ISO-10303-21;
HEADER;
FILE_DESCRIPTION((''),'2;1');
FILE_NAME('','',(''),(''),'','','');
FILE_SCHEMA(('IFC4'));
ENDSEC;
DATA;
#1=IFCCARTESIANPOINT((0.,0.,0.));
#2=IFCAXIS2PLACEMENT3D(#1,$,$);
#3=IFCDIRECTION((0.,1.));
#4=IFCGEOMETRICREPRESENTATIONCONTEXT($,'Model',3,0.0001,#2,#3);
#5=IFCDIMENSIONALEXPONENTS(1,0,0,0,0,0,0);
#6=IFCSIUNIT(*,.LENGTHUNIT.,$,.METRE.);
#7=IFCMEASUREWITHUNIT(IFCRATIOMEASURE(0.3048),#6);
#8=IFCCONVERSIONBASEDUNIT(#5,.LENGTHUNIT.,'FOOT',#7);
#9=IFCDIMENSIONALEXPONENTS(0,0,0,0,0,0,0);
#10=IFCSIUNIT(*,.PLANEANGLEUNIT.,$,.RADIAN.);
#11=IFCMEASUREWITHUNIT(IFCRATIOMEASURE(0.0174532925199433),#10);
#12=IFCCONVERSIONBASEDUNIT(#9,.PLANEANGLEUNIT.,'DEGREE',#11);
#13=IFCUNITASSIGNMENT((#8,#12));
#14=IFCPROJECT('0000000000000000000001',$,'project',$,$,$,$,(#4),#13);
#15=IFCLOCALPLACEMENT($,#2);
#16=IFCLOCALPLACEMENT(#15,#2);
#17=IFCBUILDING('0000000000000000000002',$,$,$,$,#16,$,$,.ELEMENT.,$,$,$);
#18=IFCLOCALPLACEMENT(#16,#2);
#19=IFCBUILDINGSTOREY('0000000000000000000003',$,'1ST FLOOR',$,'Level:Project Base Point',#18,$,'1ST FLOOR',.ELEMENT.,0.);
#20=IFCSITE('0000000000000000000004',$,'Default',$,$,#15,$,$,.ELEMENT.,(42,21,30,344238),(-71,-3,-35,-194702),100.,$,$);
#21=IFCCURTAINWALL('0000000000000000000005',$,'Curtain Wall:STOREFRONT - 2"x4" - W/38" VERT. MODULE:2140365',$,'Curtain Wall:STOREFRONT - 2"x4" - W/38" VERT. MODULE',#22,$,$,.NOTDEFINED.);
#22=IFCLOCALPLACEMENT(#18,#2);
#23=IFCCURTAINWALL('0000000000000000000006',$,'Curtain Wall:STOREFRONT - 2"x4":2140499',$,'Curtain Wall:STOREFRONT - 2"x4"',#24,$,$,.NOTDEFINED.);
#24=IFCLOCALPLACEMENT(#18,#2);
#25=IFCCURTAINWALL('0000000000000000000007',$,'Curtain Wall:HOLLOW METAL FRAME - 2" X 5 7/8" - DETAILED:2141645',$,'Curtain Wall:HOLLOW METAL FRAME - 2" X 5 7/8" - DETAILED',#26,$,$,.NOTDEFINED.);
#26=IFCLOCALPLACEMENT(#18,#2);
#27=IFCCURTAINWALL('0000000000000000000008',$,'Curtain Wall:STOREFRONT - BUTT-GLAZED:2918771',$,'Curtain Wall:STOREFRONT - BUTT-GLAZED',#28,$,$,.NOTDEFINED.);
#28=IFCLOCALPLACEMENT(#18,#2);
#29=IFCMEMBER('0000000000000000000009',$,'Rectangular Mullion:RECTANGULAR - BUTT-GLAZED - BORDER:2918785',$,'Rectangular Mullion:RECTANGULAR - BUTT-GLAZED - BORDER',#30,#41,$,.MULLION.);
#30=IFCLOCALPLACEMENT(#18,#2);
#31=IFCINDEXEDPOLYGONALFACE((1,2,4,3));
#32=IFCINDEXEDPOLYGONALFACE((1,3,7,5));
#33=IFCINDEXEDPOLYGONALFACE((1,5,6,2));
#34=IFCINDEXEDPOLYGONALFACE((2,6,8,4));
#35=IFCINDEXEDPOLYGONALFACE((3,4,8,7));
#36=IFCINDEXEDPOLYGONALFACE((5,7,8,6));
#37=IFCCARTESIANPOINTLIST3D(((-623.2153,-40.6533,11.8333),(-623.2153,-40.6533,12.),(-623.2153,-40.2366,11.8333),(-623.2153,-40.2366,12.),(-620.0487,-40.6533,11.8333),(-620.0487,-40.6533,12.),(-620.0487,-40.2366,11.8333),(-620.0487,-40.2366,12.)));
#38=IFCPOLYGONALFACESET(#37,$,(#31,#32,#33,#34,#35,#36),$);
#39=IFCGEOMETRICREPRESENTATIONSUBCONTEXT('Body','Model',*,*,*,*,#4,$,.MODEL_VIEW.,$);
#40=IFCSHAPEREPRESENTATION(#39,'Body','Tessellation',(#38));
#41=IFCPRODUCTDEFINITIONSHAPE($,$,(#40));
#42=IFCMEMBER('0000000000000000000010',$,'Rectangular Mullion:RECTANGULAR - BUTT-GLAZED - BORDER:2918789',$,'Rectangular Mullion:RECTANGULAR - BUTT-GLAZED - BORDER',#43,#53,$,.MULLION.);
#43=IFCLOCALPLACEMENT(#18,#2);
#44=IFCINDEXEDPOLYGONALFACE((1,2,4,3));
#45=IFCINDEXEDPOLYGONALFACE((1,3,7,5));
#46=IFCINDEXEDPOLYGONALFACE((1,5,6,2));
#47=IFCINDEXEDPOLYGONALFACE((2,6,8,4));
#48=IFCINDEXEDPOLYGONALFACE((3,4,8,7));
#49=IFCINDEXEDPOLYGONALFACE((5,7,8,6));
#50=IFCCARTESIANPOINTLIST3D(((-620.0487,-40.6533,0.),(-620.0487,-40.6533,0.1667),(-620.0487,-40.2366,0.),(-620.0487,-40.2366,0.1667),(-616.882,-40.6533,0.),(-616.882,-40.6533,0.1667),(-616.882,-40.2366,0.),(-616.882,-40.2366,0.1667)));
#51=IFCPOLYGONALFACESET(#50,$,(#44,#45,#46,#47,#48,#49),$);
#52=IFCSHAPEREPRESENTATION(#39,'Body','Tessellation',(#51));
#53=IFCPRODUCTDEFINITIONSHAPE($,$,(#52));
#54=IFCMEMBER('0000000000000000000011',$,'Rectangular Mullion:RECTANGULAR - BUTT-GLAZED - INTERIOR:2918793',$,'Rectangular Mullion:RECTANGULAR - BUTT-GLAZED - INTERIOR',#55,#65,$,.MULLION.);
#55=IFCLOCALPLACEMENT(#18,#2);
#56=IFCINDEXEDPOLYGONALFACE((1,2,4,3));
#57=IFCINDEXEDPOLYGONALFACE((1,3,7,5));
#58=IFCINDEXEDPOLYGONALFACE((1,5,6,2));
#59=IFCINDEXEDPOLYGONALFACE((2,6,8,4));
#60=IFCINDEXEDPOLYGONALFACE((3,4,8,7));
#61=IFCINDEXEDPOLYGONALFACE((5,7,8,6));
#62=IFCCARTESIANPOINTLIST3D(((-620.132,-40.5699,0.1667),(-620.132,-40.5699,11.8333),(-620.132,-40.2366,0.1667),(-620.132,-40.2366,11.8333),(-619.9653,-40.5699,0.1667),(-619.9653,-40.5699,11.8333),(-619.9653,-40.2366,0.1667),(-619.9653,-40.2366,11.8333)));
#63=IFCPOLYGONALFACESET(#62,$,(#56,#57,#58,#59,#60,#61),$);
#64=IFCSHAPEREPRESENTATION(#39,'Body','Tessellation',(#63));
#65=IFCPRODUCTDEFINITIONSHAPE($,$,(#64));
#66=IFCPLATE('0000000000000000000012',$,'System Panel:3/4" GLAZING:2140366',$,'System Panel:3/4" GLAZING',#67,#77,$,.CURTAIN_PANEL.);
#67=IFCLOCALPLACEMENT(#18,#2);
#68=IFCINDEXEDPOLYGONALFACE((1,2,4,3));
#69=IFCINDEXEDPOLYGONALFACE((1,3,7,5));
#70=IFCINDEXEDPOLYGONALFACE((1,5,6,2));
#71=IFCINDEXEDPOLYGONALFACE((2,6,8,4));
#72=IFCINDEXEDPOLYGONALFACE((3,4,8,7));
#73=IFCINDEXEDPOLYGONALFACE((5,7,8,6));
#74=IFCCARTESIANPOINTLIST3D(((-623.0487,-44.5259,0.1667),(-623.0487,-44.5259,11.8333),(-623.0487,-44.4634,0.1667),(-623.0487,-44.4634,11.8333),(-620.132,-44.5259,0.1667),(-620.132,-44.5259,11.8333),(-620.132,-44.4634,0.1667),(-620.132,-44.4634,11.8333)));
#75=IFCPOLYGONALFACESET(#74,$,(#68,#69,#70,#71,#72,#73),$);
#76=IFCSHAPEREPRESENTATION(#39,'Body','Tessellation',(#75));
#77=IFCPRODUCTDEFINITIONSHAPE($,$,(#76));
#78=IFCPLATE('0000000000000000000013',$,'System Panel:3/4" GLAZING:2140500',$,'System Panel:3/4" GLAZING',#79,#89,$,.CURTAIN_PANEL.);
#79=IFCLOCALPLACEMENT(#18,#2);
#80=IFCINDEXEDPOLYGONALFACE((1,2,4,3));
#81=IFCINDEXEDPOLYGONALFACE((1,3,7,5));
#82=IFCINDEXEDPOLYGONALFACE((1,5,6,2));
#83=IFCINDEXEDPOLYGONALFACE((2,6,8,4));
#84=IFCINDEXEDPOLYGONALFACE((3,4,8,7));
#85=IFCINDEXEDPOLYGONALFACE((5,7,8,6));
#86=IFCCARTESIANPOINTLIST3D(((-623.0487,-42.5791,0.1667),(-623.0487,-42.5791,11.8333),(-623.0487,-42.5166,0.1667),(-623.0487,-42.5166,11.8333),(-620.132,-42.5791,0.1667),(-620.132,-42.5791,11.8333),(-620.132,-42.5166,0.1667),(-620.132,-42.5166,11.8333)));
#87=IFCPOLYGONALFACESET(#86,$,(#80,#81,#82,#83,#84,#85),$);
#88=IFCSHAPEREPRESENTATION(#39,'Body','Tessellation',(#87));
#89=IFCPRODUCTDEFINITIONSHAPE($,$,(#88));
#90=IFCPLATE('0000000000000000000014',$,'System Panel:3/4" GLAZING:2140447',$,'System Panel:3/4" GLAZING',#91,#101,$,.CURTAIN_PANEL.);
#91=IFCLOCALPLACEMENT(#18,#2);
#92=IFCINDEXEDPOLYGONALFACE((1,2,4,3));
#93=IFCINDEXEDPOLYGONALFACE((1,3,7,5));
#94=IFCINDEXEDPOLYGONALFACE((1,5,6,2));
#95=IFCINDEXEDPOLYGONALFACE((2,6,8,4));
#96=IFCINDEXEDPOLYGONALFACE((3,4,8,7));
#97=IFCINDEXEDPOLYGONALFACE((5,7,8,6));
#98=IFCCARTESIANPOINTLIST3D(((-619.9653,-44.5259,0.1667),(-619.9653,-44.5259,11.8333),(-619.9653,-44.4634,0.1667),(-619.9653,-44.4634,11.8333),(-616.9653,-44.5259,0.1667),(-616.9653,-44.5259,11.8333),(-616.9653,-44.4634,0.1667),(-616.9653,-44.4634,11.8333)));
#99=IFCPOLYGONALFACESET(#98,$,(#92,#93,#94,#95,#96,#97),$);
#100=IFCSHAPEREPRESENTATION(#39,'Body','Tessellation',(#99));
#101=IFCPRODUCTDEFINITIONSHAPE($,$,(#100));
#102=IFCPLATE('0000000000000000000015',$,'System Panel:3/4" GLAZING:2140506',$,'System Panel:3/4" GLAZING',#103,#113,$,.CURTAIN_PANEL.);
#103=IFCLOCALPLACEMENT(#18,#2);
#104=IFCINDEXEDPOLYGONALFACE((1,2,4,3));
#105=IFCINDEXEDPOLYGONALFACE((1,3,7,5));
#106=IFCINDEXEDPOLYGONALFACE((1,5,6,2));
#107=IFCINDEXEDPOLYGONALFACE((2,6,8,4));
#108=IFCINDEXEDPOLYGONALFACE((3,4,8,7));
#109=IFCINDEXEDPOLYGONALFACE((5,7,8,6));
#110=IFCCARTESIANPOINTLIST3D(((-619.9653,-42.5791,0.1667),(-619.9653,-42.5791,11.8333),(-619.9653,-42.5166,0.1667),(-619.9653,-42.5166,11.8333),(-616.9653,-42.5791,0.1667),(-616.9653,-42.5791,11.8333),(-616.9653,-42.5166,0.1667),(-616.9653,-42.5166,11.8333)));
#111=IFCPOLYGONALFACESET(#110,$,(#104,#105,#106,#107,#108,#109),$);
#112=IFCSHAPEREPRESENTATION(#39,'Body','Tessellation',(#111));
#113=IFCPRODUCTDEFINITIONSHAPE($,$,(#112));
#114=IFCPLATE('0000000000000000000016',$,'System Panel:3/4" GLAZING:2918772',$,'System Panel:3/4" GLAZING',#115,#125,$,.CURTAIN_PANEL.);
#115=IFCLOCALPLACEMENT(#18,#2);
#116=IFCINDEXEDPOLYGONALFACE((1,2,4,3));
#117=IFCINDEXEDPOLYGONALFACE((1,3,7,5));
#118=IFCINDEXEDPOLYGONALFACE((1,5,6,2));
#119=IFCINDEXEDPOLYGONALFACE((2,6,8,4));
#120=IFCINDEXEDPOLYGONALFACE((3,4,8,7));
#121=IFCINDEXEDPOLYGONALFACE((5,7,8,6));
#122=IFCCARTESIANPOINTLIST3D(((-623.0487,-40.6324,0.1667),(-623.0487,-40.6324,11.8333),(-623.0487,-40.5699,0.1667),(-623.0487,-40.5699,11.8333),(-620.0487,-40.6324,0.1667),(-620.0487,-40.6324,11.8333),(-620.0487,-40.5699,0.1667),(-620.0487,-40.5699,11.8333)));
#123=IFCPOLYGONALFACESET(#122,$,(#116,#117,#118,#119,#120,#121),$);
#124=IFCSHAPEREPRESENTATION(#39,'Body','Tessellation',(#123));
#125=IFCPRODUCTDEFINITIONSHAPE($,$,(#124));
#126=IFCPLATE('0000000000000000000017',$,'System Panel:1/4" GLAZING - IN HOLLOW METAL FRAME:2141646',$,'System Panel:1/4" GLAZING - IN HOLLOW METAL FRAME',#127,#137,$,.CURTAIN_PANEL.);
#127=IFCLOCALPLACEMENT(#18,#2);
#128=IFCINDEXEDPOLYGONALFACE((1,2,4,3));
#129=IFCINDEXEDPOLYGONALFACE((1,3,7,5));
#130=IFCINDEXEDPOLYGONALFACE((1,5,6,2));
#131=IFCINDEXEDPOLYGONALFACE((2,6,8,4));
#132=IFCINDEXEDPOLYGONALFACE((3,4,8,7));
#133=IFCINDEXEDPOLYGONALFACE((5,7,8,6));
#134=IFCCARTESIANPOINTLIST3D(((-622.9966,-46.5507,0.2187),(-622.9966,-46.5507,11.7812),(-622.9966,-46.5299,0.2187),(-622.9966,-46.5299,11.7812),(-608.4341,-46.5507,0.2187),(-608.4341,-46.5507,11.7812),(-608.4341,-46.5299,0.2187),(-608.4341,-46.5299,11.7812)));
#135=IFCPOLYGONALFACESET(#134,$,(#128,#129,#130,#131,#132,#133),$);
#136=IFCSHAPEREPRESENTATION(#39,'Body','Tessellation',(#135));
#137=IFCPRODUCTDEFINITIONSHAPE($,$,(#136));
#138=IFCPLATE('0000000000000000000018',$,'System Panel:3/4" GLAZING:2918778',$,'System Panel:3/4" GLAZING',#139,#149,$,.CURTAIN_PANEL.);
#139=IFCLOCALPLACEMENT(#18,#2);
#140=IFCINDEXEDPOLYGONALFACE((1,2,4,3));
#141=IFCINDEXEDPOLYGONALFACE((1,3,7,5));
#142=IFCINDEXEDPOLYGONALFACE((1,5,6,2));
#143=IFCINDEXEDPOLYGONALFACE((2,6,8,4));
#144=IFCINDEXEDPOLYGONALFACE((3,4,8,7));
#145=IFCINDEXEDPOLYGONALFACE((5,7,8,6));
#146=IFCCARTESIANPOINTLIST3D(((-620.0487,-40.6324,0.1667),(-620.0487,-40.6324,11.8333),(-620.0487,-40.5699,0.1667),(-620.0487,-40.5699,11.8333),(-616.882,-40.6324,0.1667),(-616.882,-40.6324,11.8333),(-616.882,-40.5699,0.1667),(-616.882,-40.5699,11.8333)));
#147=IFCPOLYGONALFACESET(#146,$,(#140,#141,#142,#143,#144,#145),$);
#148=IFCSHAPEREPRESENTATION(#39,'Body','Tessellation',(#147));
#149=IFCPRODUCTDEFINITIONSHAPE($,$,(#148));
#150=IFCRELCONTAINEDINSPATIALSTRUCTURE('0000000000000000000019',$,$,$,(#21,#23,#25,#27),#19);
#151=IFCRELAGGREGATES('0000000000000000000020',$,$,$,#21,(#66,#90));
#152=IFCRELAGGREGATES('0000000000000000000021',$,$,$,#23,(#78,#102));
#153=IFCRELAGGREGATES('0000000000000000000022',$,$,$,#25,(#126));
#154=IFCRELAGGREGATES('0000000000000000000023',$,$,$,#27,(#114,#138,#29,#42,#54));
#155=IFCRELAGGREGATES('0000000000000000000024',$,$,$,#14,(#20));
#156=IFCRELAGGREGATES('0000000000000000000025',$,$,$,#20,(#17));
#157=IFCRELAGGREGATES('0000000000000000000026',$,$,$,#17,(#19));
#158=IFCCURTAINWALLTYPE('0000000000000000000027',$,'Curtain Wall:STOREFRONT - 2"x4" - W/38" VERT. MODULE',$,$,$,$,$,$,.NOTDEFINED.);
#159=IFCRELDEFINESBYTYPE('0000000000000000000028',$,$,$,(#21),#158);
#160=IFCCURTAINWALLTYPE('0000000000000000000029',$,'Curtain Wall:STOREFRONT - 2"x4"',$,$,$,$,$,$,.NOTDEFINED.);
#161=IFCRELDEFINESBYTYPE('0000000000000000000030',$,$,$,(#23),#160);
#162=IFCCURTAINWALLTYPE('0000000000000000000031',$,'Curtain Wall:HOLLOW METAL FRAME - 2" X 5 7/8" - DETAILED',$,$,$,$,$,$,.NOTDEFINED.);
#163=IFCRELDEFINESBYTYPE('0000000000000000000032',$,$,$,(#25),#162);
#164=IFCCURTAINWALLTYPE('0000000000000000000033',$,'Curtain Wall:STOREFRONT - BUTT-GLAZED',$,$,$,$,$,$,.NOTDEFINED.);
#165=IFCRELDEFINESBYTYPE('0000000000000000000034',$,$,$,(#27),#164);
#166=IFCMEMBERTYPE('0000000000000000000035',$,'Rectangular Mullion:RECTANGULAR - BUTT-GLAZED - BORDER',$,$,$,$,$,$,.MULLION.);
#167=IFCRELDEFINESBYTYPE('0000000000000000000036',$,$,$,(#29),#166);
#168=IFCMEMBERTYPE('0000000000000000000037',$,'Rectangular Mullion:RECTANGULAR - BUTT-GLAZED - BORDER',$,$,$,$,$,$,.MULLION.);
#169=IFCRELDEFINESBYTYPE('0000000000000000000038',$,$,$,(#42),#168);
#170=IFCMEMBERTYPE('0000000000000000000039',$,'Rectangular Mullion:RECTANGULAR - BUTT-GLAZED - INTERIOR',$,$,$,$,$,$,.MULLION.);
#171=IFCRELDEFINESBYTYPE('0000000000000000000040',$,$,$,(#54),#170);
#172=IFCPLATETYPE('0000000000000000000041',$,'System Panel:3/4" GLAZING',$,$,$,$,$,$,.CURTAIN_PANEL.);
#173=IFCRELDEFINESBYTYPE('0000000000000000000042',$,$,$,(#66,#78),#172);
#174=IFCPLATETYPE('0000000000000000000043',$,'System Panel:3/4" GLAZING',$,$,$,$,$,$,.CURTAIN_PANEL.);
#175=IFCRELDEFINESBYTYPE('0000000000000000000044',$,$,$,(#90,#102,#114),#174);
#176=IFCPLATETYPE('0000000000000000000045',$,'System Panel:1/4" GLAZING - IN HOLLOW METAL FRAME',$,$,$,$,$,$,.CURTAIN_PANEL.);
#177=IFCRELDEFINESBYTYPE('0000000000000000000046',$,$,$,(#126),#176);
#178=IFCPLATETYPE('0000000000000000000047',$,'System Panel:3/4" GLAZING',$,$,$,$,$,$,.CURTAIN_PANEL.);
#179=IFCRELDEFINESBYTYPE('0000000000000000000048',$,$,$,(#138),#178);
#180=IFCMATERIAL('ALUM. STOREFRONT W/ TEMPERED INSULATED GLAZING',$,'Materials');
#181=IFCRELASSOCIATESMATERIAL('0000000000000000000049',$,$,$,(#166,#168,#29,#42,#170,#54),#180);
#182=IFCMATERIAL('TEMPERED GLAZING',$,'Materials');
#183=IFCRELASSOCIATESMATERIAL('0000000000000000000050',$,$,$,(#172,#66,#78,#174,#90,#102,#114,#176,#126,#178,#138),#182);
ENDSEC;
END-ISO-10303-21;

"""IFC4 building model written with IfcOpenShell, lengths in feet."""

from ifc_helpers import new_model, entity, si_unit, converted_unit, direction, frame, frame_2d, origin, origin_2d_with_axis, place, context, subcontext, project, spatial, rectangle, extrude, source, transform, mapped, material, material_profile, profile_set, profile_usage, type_object, type_shapes, element, aggregate, save


model = new_model("IFC4")

# Units and contexts
model_context = context("Model", 3, precision=0.0001, world=origin(), true_north=direction((0.0, 1.0)))
body_context = subcontext(model_context, "Body", "Model", "MODEL_VIEW")
ifc_project = project(units=[converted_unit("LENGTHUNIT", "FOOT", entity("IfcRatioMeasure", 0.3048), si_unit("LENGTHUNIT", "METRE"), dimensions=[1, 0, 0, 0, 0, 0, 0]), converted_unit("PLANEANGLEUNIT", "DEGREE", entity("IfcRatioMeasure", 0.0174532925199433), si_unit("PLANEANGLEUNIT", "RADIAN"), dimensions=[0, 0, 0, 0, 0, 0, 0])], contexts=[model_context])

# Site, building, storey
site_placement = place(None, origin())
site = spatial("IfcSite", under=ifc_project, at=site_placement, Name="Default", CompositionType="ELEMENT", RefLatitude=(42, 21, 30, 344238), RefLongitude=(-71, -3, -35, -194702), RefElevation=100.0)
building_placement = place(site_placement, origin())
building = spatial("IfcBuilding", under=site, at=building_placement, CompositionType="ELEMENT")
storey_placement = place(building_placement, origin())
storey = spatial("IfcBuildingStorey", under=building, at=storey_placement, Name="1ST FLOOR", ObjectType="Level:Project Base Point", LongName="1ST FLOOR", CompositionType="ELEMENT", Elevation=0.0)

# Curtain walls
curtain_wall_type_1 = type_object("IfcCurtainWallType", Name="Curtain Wall:STOREFRONT - 2\"x4\" - W/38\" VERT. MODULE", PredefinedType="NOTDEFINED")
curtain_wall_1_placement = place(storey_placement, origin())
curtain_wall_1 = element("IfcCurtainWall", 1, at=curtain_wall_1_placement, inside=storey, type_object=curtain_wall_type_1, Name="Curtain Wall:STOREFRONT - 2\"x4\" - W/38\" VERT. MODULE:2140365", ObjectType="Curtain Wall:STOREFRONT - 2\"x4\" - W/38\" VERT. MODULE", PredefinedType="NOTDEFINED")
ifc_material_1 = material(Name="ALUM. STOREFRONT W/ TEMPERED INSULATED GLAZING", Category="Materials")
curtain_wall_type_2 = type_object("IfcCurtainWallType", Name="Curtain Wall:STOREFRONT - 2\"x4\"", PredefinedType="NOTDEFINED")
curtain_wall_2_placement = place(storey_placement, origin())
curtain_wall_2 = element("IfcCurtainWall", 2, at=curtain_wall_2_placement, inside=storey, type_object=curtain_wall_type_2, Name="Curtain Wall:STOREFRONT - 2\"x4\":2140499", ObjectType="Curtain Wall:STOREFRONT - 2\"x4\"", PredefinedType="NOTDEFINED")

# Curtain wall
curtain_wall_type_3 = type_object("IfcCurtainWallType", Name="Curtain Wall:HOLLOW METAL FRAME - 2\" X 5 7/8\" - DETAILED", PredefinedType="NOTDEFINED")
curtain_wall_3_placement = place(storey_placement, origin())
curtain_wall_3 = element("IfcCurtainWall", 3, at=curtain_wall_3_placement, inside=storey, type_object=curtain_wall_type_3, Name="Curtain Wall:HOLLOW METAL FRAME - 2\" X 5 7/8\" - DETAILED:2141645", ObjectType="Curtain Wall:HOLLOW METAL FRAME - 2\" X 5 7/8\" - DETAILED", PredefinedType="NOTDEFINED")

# Curtain wall, members
curtain_wall_type_4 = type_object("IfcCurtainWallType", Name="Curtain Wall:STOREFRONT - BUTT-GLAZED", PredefinedType="NOTDEFINED")
curtain_wall_4_placement = place(storey_placement, origin())
curtain_wall_4 = element("IfcCurtainWall", 4, at=curtain_wall_4_placement, inside=storey, type_object=curtain_wall_type_4, Name="Curtain Wall:STOREFRONT - BUTT-GLAZED:2918771", ObjectType="Curtain Wall:STOREFRONT - BUTT-GLAZED", PredefinedType="NOTDEFINED")
ifc_material_profile_1 = material_profile(ifc_material_1, rectangle(XDim=0.4167, YDim=0.1667, at=frame_2d((0.0, 0.0), x_axis=(1.0, 0.0))), Name="RECTANGULAR - BUTT-GLAZED - BORDER")
ifc_profile_set_1 = profile_set([ifc_material_profile_1], Name="RECTANGULAR - BUTT-GLAZED - BORDER")
ifc_profile_usage_1 = profile_usage(ifc_profile_set_1)
member_type_1 = type_object("IfcMemberType", Name="Rectangular Mullion:RECTANGULAR - BUTT-GLAZED - BORDER", PredefinedType="MULLION", material=ifc_profile_set_1)
shared_shape_1 = source(origin(), body_context, "Body", "SweptSolid", [
    extrude(rectangle(XDim=0.4167, YDim=0.1667, at=frame_2d((0.0, 0.0), x_axis=(1.0, 0.0))), frame((-0.0833, -0.1562, -3.1667), z_axis=(0.0, 0.0, 1.0), x_axis=(0.0, -1.0, 0.0)), (0.0, 0.0, 1.0), 3.1667),
])
type_shapes(member_type_1, [shared_shape_1])
member_1_placement = place(storey_placement, frame((-620.0487, -40.6012, 12.0), z_axis=(1.0, 0.0, 0.0), x_axis=(0.0, 0.0, 1.0)))
member_1 = element("IfcMember", 5, at=member_1_placement, type_object=member_type_1, material=ifc_profile_usage_1, Name="Rectangular Mullion:RECTANGULAR - BUTT-GLAZED - BORDER:2918785", ObjectType="Rectangular Mullion:RECTANGULAR - BUTT-GLAZED - BORDER", PredefinedType="MULLION", context=body_context, shape_type="MappedRepresentation", body=[
    mapped(shared_shape_1, transform((0.0, 0.0, 0.0), scale=1.0)),
])
ifc_profile_usage_2 = profile_usage(ifc_profile_set_1)
member_type_2 = type_object("IfcMemberType", Name="Rectangular Mullion:RECTANGULAR - BUTT-GLAZED - BORDER", PredefinedType="MULLION", material=ifc_profile_set_1)
shared_shape_2 = source(origin(), body_context, "Body", "SweptSolid", [
    extrude(rectangle(XDim=0.4167, YDim=0.1667, at=frame_2d((0.0, 0.0), x_axis=(1.0, 0.0))), frame((-0.0833, -0.1562, -3.1667), z_axis=(0.0, 0.0, 1.0), x_axis=(0.0, -1.0, 0.0)), (0.0, 0.0, 1.0), 3.1667),
])
type_shapes(member_type_2, [shared_shape_2])
member_2_placement = place(storey_placement, frame((-620.0487, -40.6012, 0.0), z_axis=(-1.0, 0.0, 0.0), x_axis=(0.0, 0.0, -1.0)))
member_2 = element("IfcMember", 6, at=member_2_placement, type_object=member_type_2, material=ifc_profile_usage_2, Name="Rectangular Mullion:RECTANGULAR - BUTT-GLAZED - BORDER:2918789", ObjectType="Rectangular Mullion:RECTANGULAR - BUTT-GLAZED - BORDER", PredefinedType="MULLION", context=body_context, shape_type="MappedRepresentation", body=[
    mapped(shared_shape_2, transform((0.0, 0.0, 0.0), scale=1.0)),
])
ifc_material_profile_2 = material_profile(ifc_material_1, rectangle(XDim=0.3333, YDim=0.1667, at=origin_2d_with_axis()), Name="RECTANGULAR - BUTT-GLAZED - INTERIOR")
ifc_profile_set_2 = profile_set([ifc_material_profile_2], Name="RECTANGULAR - BUTT-GLAZED - INTERIOR")
ifc_profile_usage_3 = profile_usage(ifc_profile_set_2)
member_type_3 = type_object("IfcMemberType", Name="Rectangular Mullion:RECTANGULAR - BUTT-GLAZED - INTERIOR", PredefinedType="MULLION", material=ifc_profile_set_2)
shared_shape_3 = source(origin(), body_context, "Body", "SweptSolid", [
    extrude(rectangle(XDim=0.3333, YDim=0.1667, at=origin_2d_with_axis()), frame((0.0, -0.1979, -11.6667), z_axis=(0.0, 0.0, 1.0), x_axis=(0.0, -1.0, 0.0)), (0.0, 0.0, 1.0), 11.6667),
])
type_shapes(member_type_3, [shared_shape_3])
member_3_placement = place(storey_placement, frame((-620.0487, -40.6012, 0.1667), z_axis=(0.0, 0.0, -1.0), x_axis=(1.0, 0.0, 0.0)))
member_3 = element("IfcMember", 7, at=member_3_placement, type_object=member_type_3, material=ifc_profile_usage_3, Name="Rectangular Mullion:RECTANGULAR - BUTT-GLAZED - INTERIOR:2918793", ObjectType="Rectangular Mullion:RECTANGULAR - BUTT-GLAZED - INTERIOR", PredefinedType="MULLION", context=body_context, shape_type="MappedRepresentation", body=[
    mapped(shared_shape_3, transform((0.0, 0.0, 0.0), scale=1.0)),
])

# Plates
ifc_material_2 = material(Name="TEMPERED GLAZING", Category="Materials")
plate_type_1 = type_object("IfcPlateType", Name="System Panel:3/4\" GLAZING", PredefinedType="CURTAIN_PANEL", material=ifc_material_2)
shared_shape_4 = source(origin(), body_context, "Body", "SweptSolid", [
    extrude(rectangle(XDim=0.0625, YDim=2.9167, at=origin_2d_with_axis()), frame((0.0, 0.0, 0.0), z_axis=(0.0, 0.0, 1.0), x_axis=(0.0, 1.0, 0.0)), (0.0, 0.0, 1.0), 11.6667),
])
type_shapes(plate_type_1, [shared_shape_4])
plate_1_placement = place(curtain_wall_1_placement, frame((-621.5903, -44.4946, 0.1667)))
plate_1 = element("IfcPlate", 8, at=plate_1_placement, type_object=plate_type_1, material=ifc_material_2, Name="System Panel:3/4\" GLAZING:2140366", ObjectType="System Panel:3/4\" GLAZING", PredefinedType="CURTAIN_PANEL", context=body_context, shape_type="MappedRepresentation", body=[
    mapped(shared_shape_4, transform((0.0, 0.0, 0.0), scale=1.0)),
])
plate_2_placement = place(curtain_wall_2_placement, frame((-621.5903, -42.5479, 0.1667)))
plate_2 = element("IfcPlate", 9, at=plate_2_placement, type_object=plate_type_1, material=ifc_material_2, Name="System Panel:3/4\" GLAZING:2140500", ObjectType="System Panel:3/4\" GLAZING", PredefinedType="CURTAIN_PANEL", context=body_context, shape_type="MappedRepresentation", body=[
    mapped(shared_shape_4, transform((0.0, 0.0, 0.0), scale=1.0)),
])
plate_type_2 = type_object("IfcPlateType", Name="System Panel:3/4\" GLAZING", PredefinedType="CURTAIN_PANEL", material=ifc_material_2)
shared_shape_5 = source(origin(), body_context, "Body", "SweptSolid", [
    extrude(rectangle(XDim=0.0625, YDim=3.0, at=origin_2d_with_axis()), frame((0.0, 0.0, 0.0), z_axis=(0.0, 0.0, 1.0), x_axis=(0.0, 1.0, 0.0)), (0.0, 0.0, 1.0), 11.6667),
])
type_shapes(plate_type_2, [shared_shape_5])
plate_3_placement = place(curtain_wall_1_placement, frame((-618.4653, -44.4946, 0.1667)))
plate_3 = element("IfcPlate", 10, at=plate_3_placement, type_object=plate_type_2, material=ifc_material_2, Name="System Panel:3/4\" GLAZING:2140447", ObjectType="System Panel:3/4\" GLAZING", PredefinedType="CURTAIN_PANEL", context=body_context, shape_type="MappedRepresentation", body=[
    mapped(shared_shape_5, transform((0.0, 0.0, 0.0), scale=1.0)),
])
aggregate(curtain_wall_1, [plate_1, plate_3])
plate_4_placement = place(curtain_wall_2_placement, frame((-618.4653, -42.5479, 0.1667)))
plate_4 = element("IfcPlate", 11, at=plate_4_placement, type_object=plate_type_2, material=ifc_material_2, Name="System Panel:3/4\" GLAZING:2140506", ObjectType="System Panel:3/4\" GLAZING", PredefinedType="CURTAIN_PANEL", context=body_context, shape_type="MappedRepresentation", body=[
    mapped(shared_shape_5, transform((0.0, 0.0, 0.0), scale=1.0)),
])
aggregate(curtain_wall_2, [plate_2, plate_4])
plate_5_placement = place(curtain_wall_4_placement, frame((-621.5487, -40.6012, 0.1667)))
plate_5 = element("IfcPlate", 12, at=plate_5_placement, type_object=plate_type_2, material=ifc_material_2, Name="System Panel:3/4\" GLAZING:2918772", ObjectType="System Panel:3/4\" GLAZING", PredefinedType="CURTAIN_PANEL", context=body_context, shape_type="MappedRepresentation", body=[
    mapped(shared_shape_5, transform((0.0, 0.0, 0.0), scale=1.0)),
])
plate_type_3 = type_object("IfcPlateType", Name="System Panel:1/4\" GLAZING - IN HOLLOW METAL FRAME", PredefinedType="CURTAIN_PANEL", material=ifc_material_2)
shared_shape_6 = source(origin(), body_context, "Body", "SweptSolid", [
    extrude(rectangle(XDim=0.0208, YDim=14.5625, at=frame_2d((0.0, 0.0), x_axis=(1.0, 0.0))), frame((7.2812, 0.0104, 0.0), z_axis=(0.0, 0.0, 1.0), x_axis=(0.0, 1.0, 0.0)), (0.0, 0.0, 1.0), 11.5625),
])
type_shapes(plate_type_3, [shared_shape_6])
plate_6_placement = place(curtain_wall_3_placement, frame((-622.9966, -46.5507, 0.2188)))
plate_6 = element("IfcPlate", 13, at=plate_6_placement, type_object=plate_type_3, material=ifc_material_2, Name="System Panel:1/4\" GLAZING - IN HOLLOW METAL FRAME:2141646", ObjectType="System Panel:1/4\" GLAZING - IN HOLLOW METAL FRAME", PredefinedType="CURTAIN_PANEL", context=body_context, shape_type="MappedRepresentation", body=[
    mapped(shared_shape_6, transform((0.0, 0.0, 0.0), scale=1.0)),
])
aggregate(curtain_wall_3, [plate_6])
plate_type_4 = type_object("IfcPlateType", Name="System Panel:3/4\" GLAZING", PredefinedType="CURTAIN_PANEL", material=ifc_material_2)
shared_shape_7 = source(origin(), body_context, "Body", "SweptSolid", [
    extrude(rectangle(XDim=0.0625, YDim=3.1667, at=origin_2d_with_axis()), frame((0.0, 0.0, 0.0), z_axis=(0.0, 0.0, 1.0), x_axis=(0.0, 1.0, 0.0)), (0.0, 0.0, 1.0), 11.6667),
])
type_shapes(plate_type_4, [shared_shape_7])
plate_7_placement = place(curtain_wall_4_placement, frame((-618.4653, -40.6012, 0.1667)))
plate_7 = element("IfcPlate", 14, at=plate_7_placement, type_object=plate_type_4, material=ifc_material_2, Name="System Panel:3/4\" GLAZING:2918778", ObjectType="System Panel:3/4\" GLAZING", PredefinedType="CURTAIN_PANEL", context=body_context, shape_type="MappedRepresentation", body=[
    mapped(shared_shape_7, transform((0.0, 0.0, 0.0), scale=1.0)),
])
aggregate(curtain_wall_4, [plate_5, plate_7, member_1, member_2, member_3])

save(model, "model.ifc")
